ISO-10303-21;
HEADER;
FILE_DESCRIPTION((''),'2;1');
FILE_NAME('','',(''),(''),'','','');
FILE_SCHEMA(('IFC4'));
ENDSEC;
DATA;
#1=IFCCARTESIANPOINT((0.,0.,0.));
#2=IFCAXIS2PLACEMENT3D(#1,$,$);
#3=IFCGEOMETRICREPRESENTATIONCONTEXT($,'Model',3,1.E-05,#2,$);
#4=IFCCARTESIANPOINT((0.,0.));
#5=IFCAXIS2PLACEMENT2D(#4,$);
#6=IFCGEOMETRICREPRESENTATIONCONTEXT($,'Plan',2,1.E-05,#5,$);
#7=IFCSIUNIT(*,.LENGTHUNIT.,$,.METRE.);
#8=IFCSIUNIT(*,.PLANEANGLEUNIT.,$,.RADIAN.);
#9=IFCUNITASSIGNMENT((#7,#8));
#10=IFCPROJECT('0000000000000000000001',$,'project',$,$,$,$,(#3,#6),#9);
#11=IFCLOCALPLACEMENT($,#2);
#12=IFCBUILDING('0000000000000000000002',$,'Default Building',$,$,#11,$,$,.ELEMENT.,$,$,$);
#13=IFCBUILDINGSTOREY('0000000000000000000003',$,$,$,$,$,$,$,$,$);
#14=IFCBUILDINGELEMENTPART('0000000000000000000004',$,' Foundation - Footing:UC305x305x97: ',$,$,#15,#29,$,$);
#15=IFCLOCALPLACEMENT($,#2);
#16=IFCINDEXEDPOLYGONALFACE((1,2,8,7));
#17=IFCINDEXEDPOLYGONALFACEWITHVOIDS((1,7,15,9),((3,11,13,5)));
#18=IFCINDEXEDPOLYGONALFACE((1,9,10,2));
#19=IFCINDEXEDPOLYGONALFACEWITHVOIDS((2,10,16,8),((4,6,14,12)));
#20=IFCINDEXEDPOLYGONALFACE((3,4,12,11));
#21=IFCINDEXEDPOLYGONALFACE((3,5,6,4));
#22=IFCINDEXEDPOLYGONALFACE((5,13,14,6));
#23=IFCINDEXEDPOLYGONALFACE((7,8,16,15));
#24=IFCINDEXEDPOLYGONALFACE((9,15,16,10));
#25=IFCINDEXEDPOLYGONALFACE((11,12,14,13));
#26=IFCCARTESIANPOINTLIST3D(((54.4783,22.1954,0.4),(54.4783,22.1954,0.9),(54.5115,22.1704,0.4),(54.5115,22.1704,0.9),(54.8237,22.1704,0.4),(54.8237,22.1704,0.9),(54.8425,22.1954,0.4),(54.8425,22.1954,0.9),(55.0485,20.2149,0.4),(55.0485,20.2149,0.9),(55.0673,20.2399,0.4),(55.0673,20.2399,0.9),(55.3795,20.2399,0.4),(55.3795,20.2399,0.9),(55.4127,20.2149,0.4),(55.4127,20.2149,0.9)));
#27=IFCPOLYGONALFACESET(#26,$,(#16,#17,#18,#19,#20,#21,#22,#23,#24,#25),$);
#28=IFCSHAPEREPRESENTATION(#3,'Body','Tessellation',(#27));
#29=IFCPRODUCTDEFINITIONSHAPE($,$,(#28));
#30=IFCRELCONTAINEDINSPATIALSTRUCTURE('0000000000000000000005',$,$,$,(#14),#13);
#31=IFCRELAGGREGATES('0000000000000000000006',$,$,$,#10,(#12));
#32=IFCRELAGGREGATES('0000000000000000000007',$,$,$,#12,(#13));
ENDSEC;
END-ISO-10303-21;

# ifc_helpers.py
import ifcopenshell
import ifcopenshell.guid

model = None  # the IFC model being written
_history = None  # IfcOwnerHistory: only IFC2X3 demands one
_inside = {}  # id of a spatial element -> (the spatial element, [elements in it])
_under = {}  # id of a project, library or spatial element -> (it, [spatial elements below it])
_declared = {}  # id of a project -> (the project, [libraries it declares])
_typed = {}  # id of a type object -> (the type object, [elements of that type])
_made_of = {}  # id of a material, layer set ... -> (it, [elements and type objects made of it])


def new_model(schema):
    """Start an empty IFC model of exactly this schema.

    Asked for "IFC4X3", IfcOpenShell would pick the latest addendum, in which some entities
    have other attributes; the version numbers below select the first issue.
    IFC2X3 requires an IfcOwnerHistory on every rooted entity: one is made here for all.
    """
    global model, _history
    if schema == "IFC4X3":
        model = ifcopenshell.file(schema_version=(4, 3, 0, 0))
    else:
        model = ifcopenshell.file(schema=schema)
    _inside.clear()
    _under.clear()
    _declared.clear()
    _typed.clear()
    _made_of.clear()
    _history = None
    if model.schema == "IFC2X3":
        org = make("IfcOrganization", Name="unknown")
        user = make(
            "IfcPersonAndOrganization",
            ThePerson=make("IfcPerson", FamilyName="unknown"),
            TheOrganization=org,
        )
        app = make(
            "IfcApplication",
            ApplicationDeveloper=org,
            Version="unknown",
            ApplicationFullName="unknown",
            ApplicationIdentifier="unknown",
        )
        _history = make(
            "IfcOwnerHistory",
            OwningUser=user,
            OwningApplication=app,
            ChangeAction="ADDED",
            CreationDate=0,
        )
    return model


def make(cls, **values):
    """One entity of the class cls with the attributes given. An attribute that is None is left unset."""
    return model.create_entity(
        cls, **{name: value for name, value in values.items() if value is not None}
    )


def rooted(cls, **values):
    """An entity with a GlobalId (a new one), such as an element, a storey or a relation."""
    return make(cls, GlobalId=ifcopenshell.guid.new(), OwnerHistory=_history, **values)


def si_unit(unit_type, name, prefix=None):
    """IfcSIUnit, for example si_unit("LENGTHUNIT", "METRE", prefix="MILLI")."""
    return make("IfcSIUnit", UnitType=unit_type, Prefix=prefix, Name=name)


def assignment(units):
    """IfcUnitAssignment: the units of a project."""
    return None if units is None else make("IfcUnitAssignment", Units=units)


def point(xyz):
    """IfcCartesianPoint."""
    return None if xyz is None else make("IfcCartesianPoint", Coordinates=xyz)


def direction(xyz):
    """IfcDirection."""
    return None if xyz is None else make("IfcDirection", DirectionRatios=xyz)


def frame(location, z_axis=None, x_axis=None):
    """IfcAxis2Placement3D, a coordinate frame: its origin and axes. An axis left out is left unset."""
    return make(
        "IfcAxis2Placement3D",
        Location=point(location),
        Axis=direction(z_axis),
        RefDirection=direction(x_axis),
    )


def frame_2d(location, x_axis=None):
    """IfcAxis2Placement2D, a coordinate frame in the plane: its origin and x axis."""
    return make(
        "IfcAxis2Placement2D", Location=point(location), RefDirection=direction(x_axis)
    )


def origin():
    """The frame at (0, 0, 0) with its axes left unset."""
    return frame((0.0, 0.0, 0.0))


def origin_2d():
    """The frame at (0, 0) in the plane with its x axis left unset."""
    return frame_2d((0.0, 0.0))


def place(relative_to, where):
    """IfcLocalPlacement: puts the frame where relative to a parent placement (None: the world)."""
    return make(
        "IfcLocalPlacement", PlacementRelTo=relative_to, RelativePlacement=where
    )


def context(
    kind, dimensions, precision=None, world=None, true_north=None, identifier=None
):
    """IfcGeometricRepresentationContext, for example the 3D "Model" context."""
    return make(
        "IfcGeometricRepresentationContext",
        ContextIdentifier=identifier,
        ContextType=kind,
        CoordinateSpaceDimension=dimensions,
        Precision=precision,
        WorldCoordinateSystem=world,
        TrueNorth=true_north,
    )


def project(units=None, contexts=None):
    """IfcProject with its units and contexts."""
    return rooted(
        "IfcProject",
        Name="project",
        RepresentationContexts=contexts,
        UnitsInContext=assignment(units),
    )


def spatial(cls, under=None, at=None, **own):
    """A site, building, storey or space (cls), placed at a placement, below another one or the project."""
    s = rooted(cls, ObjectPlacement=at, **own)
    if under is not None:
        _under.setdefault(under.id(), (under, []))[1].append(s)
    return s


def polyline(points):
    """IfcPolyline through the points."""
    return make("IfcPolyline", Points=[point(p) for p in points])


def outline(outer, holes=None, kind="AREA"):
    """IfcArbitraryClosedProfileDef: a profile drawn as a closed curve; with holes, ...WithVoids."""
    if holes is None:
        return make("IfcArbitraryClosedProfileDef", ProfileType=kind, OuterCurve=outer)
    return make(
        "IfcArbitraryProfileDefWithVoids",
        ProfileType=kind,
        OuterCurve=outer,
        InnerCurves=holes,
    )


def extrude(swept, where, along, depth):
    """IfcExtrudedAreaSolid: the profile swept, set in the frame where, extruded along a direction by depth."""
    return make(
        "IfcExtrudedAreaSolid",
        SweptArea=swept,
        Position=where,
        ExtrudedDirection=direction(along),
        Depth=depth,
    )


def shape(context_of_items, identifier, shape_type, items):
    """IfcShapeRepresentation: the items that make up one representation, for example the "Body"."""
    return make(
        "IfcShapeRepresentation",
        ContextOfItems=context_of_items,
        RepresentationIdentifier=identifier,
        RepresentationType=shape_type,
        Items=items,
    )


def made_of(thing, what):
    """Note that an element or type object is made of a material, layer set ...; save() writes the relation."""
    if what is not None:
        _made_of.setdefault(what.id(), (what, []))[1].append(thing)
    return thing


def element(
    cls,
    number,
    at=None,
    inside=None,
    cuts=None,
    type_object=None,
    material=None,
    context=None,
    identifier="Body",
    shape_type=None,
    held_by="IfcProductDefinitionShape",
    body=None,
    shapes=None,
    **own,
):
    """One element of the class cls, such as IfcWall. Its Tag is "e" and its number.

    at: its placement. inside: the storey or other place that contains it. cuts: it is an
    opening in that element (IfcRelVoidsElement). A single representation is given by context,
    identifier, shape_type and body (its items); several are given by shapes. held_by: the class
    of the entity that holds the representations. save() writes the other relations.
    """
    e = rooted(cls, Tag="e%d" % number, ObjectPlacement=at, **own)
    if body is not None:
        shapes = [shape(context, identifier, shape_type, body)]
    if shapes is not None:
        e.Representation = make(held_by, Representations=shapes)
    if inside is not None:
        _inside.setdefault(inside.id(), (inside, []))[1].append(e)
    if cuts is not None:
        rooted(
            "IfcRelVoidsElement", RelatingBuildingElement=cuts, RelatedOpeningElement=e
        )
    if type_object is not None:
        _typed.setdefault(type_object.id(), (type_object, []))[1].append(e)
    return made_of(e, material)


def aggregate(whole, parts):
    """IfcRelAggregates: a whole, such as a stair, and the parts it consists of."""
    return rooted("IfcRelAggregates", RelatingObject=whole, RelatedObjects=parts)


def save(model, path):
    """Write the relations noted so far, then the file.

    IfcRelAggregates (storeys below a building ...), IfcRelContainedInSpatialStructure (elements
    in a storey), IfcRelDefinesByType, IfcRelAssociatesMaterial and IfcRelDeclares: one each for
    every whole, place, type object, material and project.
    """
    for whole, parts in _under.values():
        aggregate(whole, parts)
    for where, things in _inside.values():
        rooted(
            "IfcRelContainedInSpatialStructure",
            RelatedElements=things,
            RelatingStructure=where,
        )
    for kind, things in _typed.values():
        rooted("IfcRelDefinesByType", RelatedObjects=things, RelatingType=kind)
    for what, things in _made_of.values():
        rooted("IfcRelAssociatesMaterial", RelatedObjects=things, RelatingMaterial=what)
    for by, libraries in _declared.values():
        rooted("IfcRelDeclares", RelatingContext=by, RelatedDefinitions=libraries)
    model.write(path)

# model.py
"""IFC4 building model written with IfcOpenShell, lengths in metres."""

from ifc_helpers import new_model, si_unit, origin, origin_2d, place, context, project, spatial, polyline, outline, extrude, element, save


model = new_model("IFC4")

# Units and contexts
model_context = context("Model", 3, precision=1e-05, world=origin())
plan_context = context("Plan", 2, precision=1e-05, world=origin_2d())
ifc_project = project(units=[si_unit("LENGTHUNIT", "METRE"), si_unit("PLANEANGLEUNIT", "RADIAN")], contexts=[model_context, plan_context])

# Building, storey
building_placement = place(None, origin())
building = spatial("IfcBuilding", under=ifc_project, at=building_placement, Name="Default Building", CompositionType="ELEMENT")
storey = spatial("IfcBuildingStorey", under=building)

# Building element part, opening
building_element_part_1 = element("IfcBuildingElementPart", 1, inside=storey, Name=" Foundation - Footing:UC305x305x97: ", context=model_context, shape_type="SweptSolid", body=[
    extrude(outline(polyline([(55.0485, 20.2149, 0.4), (55.4127, 20.2149, 0.4), (54.8425, 22.1954, 0.4), (54.4783, 22.1954, 0.4), (55.0485, 20.2149, 0.4)])), None, (0.0, 0.0, 1.0), 0.5),
])
element("IfcOpeningElement", 2, inside=storey, cuts=building_element_part_1, context=model_context, shape_type="SweptSolid", body=[
    extrude(outline(polyline([(55.0673, 20.2399, 0.4), (55.3795, 20.2399, 0.4), (54.8237, 22.1704, 0.4), (54.5115, 22.1704, 0.4), (55.0673, 20.2399, 0.4)])), None, (0.0, 0.0, 1.0), 0.5),
])

save(model, "model.ifc")
